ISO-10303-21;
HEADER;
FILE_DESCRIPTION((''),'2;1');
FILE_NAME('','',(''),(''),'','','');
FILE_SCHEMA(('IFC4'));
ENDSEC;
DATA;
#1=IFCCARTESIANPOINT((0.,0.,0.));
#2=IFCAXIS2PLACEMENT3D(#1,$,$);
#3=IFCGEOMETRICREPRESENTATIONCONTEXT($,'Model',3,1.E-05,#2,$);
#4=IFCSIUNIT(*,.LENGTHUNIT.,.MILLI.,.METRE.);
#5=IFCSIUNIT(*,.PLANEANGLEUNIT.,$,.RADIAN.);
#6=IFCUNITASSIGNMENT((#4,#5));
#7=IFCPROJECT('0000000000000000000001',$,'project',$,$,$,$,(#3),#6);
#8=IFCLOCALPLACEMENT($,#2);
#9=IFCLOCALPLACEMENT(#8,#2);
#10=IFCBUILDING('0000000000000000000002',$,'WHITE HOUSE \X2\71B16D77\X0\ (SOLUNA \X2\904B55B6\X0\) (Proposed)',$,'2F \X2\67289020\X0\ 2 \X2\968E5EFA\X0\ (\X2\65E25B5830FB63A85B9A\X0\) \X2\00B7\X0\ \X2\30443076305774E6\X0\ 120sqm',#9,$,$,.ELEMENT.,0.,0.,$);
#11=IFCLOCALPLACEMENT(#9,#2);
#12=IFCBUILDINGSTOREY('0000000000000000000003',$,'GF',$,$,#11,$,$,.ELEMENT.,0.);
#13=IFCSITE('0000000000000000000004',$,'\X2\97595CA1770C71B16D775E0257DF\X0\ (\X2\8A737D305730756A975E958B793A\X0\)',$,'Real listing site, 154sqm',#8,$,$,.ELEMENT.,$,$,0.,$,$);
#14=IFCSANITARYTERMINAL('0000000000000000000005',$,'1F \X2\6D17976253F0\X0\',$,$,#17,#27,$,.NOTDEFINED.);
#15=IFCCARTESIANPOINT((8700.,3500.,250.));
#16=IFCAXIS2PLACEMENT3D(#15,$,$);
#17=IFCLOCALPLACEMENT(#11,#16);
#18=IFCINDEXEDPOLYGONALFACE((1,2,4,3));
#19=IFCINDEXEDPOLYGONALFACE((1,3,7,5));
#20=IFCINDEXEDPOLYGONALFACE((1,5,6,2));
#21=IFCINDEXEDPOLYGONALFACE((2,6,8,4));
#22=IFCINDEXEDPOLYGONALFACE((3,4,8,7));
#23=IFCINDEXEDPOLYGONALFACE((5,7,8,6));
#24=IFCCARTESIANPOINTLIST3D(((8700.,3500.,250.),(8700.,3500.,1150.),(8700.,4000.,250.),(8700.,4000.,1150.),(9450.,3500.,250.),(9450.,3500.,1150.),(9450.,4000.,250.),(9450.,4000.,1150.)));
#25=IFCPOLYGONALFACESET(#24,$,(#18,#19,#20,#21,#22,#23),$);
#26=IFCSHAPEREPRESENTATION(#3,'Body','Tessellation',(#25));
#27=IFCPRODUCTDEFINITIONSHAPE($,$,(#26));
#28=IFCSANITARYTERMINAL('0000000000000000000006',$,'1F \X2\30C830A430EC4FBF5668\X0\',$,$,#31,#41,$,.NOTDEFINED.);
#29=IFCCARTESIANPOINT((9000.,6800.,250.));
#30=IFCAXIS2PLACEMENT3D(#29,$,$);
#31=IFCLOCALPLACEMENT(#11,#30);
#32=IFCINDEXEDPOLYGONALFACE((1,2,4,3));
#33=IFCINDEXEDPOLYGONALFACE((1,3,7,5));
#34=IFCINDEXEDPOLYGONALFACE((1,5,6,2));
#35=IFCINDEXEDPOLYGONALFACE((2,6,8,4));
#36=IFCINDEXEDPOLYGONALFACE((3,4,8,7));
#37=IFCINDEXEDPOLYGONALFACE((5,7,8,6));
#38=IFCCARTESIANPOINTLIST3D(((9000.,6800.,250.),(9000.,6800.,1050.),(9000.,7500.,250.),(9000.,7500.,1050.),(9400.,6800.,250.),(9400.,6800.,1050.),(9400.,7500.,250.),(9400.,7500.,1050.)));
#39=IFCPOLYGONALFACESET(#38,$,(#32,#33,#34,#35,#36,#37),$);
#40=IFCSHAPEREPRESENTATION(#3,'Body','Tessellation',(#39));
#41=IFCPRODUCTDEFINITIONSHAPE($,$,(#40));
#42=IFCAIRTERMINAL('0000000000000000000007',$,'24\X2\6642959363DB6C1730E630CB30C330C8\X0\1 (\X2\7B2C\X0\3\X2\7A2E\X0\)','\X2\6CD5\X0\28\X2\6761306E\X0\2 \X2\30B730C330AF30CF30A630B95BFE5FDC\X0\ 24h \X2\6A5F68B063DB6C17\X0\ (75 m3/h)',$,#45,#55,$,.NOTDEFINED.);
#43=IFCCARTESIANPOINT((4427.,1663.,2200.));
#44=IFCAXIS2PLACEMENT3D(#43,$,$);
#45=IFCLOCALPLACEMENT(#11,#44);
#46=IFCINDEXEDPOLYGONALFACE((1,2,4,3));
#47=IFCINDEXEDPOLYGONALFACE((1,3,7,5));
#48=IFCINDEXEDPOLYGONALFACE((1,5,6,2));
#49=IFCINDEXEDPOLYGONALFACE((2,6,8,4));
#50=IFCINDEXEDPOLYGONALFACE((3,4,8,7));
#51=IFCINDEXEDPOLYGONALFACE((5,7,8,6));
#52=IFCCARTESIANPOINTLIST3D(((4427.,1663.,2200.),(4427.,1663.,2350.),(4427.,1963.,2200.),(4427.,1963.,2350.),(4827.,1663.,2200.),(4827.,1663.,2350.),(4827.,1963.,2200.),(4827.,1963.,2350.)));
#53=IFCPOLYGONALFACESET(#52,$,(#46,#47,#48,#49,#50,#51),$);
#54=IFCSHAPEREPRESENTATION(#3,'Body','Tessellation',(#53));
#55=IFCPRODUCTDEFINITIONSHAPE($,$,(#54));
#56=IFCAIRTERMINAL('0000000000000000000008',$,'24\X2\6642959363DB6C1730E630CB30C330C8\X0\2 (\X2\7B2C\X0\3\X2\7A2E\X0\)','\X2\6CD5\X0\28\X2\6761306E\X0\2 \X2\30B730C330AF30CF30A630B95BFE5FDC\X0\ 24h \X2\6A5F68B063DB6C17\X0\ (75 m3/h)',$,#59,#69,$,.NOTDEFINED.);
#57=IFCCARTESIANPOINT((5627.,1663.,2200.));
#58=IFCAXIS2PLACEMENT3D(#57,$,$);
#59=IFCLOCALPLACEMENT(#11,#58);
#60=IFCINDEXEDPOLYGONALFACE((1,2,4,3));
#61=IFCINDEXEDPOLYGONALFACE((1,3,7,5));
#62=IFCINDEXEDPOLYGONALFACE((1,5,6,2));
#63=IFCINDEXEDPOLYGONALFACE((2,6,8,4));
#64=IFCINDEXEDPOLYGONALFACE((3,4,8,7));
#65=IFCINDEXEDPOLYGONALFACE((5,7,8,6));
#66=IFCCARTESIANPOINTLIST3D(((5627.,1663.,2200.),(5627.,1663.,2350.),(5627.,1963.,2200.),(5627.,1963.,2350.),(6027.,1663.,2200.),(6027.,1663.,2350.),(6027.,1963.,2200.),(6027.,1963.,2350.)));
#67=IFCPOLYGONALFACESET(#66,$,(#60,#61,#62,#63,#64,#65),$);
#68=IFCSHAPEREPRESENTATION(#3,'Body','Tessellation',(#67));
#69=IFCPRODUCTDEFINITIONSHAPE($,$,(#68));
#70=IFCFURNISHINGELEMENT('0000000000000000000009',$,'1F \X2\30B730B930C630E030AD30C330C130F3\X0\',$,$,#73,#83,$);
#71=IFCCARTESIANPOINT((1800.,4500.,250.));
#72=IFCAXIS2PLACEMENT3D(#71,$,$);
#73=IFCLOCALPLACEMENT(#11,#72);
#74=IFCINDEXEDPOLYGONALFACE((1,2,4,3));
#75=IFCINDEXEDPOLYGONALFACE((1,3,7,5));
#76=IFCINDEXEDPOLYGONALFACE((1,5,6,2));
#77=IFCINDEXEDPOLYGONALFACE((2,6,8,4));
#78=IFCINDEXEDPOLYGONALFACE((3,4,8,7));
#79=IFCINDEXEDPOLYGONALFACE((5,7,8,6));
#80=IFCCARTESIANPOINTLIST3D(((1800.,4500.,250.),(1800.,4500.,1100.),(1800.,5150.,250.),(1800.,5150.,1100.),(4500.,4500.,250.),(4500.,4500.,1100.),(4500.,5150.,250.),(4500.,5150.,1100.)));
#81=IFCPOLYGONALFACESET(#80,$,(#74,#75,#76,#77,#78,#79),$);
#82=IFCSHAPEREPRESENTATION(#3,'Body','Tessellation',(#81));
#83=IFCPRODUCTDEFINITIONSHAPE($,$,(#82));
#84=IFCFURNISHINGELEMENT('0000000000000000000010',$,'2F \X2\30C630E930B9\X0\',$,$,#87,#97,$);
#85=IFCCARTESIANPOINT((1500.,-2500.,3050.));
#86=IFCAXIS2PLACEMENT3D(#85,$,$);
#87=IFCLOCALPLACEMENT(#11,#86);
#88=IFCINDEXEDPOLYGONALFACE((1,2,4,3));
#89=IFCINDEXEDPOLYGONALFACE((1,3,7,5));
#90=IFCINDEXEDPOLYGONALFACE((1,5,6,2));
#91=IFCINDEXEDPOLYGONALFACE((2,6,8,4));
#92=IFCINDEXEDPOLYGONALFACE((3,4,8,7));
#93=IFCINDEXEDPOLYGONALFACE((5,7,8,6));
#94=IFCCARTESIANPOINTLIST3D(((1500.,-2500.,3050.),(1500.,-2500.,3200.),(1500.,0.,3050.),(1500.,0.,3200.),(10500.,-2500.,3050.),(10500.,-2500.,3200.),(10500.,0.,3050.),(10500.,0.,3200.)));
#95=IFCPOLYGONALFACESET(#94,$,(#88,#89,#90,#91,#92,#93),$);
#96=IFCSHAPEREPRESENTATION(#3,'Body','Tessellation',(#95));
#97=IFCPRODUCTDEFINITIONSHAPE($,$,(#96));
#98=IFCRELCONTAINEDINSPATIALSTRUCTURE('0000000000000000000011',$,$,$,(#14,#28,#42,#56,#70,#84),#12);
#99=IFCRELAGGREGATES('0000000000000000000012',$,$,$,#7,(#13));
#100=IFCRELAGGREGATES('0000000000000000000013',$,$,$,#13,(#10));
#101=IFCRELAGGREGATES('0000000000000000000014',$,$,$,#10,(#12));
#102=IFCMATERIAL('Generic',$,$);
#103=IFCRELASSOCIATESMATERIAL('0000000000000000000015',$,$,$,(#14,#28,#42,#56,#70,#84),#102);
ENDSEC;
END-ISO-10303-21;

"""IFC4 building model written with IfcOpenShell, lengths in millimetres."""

from ifc_helpers import new_model, si_unit, frame, frame_2d, origin, place, context, project, spatial, rectangle, extrude, material, element, save


model = new_model("IFC4")

# Units and contexts
model_context = context("Model", 3, precision=1e-05, world=origin())
ifc_project = project(units=[si_unit("LENGTHUNIT", "METRE", prefix="MILLI"), si_unit("PLANEANGLEUNIT", "RADIAN")], contexts=[model_context])

# Site, building, storey
site_placement = place(None, origin())
site = spatial("IfcSite", under=ifc_project, at=site_placement, Name="静岡県熱海市域 (詳細地番非開示)", ObjectType="Real listing site, 154sqm", CompositionType="ELEMENT", RefElevation=0.0)
building_placement = place(site_placement, origin())
building = spatial("IfcBuilding", under=site, at=building_placement, Name="WHITE HOUSE 熱海 (SOLUNA 運営) (Proposed)", ObjectType="2F 木造 2 階建 (既存・推定) · いぶし瓦 120sqm", CompositionType="ELEMENT", ElevationOfRefHeight=0.0, ElevationOfTerrain=0.0)
storey_placement = place(building_placement, origin())
storey = spatial("IfcBuildingStorey", under=building, at=storey_placement, Name="GF", CompositionType="ELEMENT", Elevation=0.0)

# Shared definitions
ifc_material_1 = material(Name="Generic")

# Sanitary terminals
sanitary_terminal_1_placement = place(storey_placement, frame((8700.0, 3500.0, 250.0)))
element("IfcSanitaryTerminal", 1, at=sanitary_terminal_1_placement, inside=storey, material=ifc_material_1, Name="1F 洗面台", PredefinedType="NOTDEFINED", context=model_context, shape_type="SweptSolid", body=[
    extrude(rectangle(XDim=750.0, YDim=500.0, at=frame_2d((375.0, 250.0))), frame((8700.0, 3500.0, 250.0)), (0.0, 0.0, 1.0), 900.0),
])
sanitary_terminal_2_placement = place(storey_placement, frame((9000.0, 6800.0, 250.0)))
element("IfcSanitaryTerminal", 2, at=sanitary_terminal_2_placement, inside=storey, material=ifc_material_1, Name="1F トイレ便器", PredefinedType="NOTDEFINED", context=model_context, shape_type="SweptSolid", body=[
    extrude(rectangle(XDim=400.0, YDim=700.0, at=frame_2d((200.0, 350.0))), frame((9000.0, 6800.0, 250.0)), (0.0, 0.0, 1.0), 800.0),
])

# Air terminals
air_terminal_1_placement = place(storey_placement, frame((4427.0, 1663.0, 2200.0)))
element("IfcAirTerminal", 3, at=air_terminal_1_placement, inside=storey, material=ifc_material_1, Name="24時間換気ユニット1 (第3種)", Description="法28条の2 シックハウス対応 24h 機械換気 (75 m3/h)", PredefinedType="NOTDEFINED", context=model_context, shape_type="SweptSolid", body=[
    extrude(rectangle(XDim=400.0, YDim=300.0, at=frame_2d((200.0, 150.0))), frame((4427.0, 1663.0, 2200.0)), (0.0, 0.0, 1.0), 150.0),
])
air_terminal_2_placement = place(storey_placement, frame((5627.0, 1663.0, 2200.0)))
element("IfcAirTerminal", 4, at=air_terminal_2_placement, inside=storey, material=ifc_material_1, Name="24時間換気ユニット2 (第3種)", Description="法28条の2 シックハウス対応 24h 機械換気 (75 m3/h)", PredefinedType="NOTDEFINED", context=model_context, shape_type="SweptSolid", body=[
    extrude(rectangle(XDim=400.0, YDim=300.0, at=frame_2d((200.0, 150.0))), frame((5627.0, 1663.0, 2200.0)), (0.0, 0.0, 1.0), 150.0),
])

# Furnishing elements
furnishing_1_placement = place(storey_placement, frame((1800.0, 4500.0, 250.0)))
element("IfcFurnishingElement", 5, at=furnishing_1_placement, inside=storey, material=ifc_material_1, Name="1F システムキッチン", context=model_context, shape_type="SweptSolid", body=[
    extrude(rectangle(XDim=2700.0, YDim=650.0, at=frame_2d((1350.0, 325.0))), frame((1800.0, 4500.0, 250.0)), (0.0, 0.0, 1.0), 850.0),
])
furnishing_2_placement = place(storey_placement, frame((1500.0, -2500.0, 3050.0)))
element("IfcFurnishingElement", 6, at=furnishing_2_placement, inside=storey, material=ifc_material_1, Name="2F テラス", context=model_context, shape_type="SweptSolid", body=[
    extrude(rectangle(XDim=9000.0, YDim=2500.0, at=frame_2d((4500.0, 1250.0))), frame((1500.0, -2500.0, 3050.0)), (0.0, 0.0, 1.0), 150.0),
])

save(model, "model.ifc")
